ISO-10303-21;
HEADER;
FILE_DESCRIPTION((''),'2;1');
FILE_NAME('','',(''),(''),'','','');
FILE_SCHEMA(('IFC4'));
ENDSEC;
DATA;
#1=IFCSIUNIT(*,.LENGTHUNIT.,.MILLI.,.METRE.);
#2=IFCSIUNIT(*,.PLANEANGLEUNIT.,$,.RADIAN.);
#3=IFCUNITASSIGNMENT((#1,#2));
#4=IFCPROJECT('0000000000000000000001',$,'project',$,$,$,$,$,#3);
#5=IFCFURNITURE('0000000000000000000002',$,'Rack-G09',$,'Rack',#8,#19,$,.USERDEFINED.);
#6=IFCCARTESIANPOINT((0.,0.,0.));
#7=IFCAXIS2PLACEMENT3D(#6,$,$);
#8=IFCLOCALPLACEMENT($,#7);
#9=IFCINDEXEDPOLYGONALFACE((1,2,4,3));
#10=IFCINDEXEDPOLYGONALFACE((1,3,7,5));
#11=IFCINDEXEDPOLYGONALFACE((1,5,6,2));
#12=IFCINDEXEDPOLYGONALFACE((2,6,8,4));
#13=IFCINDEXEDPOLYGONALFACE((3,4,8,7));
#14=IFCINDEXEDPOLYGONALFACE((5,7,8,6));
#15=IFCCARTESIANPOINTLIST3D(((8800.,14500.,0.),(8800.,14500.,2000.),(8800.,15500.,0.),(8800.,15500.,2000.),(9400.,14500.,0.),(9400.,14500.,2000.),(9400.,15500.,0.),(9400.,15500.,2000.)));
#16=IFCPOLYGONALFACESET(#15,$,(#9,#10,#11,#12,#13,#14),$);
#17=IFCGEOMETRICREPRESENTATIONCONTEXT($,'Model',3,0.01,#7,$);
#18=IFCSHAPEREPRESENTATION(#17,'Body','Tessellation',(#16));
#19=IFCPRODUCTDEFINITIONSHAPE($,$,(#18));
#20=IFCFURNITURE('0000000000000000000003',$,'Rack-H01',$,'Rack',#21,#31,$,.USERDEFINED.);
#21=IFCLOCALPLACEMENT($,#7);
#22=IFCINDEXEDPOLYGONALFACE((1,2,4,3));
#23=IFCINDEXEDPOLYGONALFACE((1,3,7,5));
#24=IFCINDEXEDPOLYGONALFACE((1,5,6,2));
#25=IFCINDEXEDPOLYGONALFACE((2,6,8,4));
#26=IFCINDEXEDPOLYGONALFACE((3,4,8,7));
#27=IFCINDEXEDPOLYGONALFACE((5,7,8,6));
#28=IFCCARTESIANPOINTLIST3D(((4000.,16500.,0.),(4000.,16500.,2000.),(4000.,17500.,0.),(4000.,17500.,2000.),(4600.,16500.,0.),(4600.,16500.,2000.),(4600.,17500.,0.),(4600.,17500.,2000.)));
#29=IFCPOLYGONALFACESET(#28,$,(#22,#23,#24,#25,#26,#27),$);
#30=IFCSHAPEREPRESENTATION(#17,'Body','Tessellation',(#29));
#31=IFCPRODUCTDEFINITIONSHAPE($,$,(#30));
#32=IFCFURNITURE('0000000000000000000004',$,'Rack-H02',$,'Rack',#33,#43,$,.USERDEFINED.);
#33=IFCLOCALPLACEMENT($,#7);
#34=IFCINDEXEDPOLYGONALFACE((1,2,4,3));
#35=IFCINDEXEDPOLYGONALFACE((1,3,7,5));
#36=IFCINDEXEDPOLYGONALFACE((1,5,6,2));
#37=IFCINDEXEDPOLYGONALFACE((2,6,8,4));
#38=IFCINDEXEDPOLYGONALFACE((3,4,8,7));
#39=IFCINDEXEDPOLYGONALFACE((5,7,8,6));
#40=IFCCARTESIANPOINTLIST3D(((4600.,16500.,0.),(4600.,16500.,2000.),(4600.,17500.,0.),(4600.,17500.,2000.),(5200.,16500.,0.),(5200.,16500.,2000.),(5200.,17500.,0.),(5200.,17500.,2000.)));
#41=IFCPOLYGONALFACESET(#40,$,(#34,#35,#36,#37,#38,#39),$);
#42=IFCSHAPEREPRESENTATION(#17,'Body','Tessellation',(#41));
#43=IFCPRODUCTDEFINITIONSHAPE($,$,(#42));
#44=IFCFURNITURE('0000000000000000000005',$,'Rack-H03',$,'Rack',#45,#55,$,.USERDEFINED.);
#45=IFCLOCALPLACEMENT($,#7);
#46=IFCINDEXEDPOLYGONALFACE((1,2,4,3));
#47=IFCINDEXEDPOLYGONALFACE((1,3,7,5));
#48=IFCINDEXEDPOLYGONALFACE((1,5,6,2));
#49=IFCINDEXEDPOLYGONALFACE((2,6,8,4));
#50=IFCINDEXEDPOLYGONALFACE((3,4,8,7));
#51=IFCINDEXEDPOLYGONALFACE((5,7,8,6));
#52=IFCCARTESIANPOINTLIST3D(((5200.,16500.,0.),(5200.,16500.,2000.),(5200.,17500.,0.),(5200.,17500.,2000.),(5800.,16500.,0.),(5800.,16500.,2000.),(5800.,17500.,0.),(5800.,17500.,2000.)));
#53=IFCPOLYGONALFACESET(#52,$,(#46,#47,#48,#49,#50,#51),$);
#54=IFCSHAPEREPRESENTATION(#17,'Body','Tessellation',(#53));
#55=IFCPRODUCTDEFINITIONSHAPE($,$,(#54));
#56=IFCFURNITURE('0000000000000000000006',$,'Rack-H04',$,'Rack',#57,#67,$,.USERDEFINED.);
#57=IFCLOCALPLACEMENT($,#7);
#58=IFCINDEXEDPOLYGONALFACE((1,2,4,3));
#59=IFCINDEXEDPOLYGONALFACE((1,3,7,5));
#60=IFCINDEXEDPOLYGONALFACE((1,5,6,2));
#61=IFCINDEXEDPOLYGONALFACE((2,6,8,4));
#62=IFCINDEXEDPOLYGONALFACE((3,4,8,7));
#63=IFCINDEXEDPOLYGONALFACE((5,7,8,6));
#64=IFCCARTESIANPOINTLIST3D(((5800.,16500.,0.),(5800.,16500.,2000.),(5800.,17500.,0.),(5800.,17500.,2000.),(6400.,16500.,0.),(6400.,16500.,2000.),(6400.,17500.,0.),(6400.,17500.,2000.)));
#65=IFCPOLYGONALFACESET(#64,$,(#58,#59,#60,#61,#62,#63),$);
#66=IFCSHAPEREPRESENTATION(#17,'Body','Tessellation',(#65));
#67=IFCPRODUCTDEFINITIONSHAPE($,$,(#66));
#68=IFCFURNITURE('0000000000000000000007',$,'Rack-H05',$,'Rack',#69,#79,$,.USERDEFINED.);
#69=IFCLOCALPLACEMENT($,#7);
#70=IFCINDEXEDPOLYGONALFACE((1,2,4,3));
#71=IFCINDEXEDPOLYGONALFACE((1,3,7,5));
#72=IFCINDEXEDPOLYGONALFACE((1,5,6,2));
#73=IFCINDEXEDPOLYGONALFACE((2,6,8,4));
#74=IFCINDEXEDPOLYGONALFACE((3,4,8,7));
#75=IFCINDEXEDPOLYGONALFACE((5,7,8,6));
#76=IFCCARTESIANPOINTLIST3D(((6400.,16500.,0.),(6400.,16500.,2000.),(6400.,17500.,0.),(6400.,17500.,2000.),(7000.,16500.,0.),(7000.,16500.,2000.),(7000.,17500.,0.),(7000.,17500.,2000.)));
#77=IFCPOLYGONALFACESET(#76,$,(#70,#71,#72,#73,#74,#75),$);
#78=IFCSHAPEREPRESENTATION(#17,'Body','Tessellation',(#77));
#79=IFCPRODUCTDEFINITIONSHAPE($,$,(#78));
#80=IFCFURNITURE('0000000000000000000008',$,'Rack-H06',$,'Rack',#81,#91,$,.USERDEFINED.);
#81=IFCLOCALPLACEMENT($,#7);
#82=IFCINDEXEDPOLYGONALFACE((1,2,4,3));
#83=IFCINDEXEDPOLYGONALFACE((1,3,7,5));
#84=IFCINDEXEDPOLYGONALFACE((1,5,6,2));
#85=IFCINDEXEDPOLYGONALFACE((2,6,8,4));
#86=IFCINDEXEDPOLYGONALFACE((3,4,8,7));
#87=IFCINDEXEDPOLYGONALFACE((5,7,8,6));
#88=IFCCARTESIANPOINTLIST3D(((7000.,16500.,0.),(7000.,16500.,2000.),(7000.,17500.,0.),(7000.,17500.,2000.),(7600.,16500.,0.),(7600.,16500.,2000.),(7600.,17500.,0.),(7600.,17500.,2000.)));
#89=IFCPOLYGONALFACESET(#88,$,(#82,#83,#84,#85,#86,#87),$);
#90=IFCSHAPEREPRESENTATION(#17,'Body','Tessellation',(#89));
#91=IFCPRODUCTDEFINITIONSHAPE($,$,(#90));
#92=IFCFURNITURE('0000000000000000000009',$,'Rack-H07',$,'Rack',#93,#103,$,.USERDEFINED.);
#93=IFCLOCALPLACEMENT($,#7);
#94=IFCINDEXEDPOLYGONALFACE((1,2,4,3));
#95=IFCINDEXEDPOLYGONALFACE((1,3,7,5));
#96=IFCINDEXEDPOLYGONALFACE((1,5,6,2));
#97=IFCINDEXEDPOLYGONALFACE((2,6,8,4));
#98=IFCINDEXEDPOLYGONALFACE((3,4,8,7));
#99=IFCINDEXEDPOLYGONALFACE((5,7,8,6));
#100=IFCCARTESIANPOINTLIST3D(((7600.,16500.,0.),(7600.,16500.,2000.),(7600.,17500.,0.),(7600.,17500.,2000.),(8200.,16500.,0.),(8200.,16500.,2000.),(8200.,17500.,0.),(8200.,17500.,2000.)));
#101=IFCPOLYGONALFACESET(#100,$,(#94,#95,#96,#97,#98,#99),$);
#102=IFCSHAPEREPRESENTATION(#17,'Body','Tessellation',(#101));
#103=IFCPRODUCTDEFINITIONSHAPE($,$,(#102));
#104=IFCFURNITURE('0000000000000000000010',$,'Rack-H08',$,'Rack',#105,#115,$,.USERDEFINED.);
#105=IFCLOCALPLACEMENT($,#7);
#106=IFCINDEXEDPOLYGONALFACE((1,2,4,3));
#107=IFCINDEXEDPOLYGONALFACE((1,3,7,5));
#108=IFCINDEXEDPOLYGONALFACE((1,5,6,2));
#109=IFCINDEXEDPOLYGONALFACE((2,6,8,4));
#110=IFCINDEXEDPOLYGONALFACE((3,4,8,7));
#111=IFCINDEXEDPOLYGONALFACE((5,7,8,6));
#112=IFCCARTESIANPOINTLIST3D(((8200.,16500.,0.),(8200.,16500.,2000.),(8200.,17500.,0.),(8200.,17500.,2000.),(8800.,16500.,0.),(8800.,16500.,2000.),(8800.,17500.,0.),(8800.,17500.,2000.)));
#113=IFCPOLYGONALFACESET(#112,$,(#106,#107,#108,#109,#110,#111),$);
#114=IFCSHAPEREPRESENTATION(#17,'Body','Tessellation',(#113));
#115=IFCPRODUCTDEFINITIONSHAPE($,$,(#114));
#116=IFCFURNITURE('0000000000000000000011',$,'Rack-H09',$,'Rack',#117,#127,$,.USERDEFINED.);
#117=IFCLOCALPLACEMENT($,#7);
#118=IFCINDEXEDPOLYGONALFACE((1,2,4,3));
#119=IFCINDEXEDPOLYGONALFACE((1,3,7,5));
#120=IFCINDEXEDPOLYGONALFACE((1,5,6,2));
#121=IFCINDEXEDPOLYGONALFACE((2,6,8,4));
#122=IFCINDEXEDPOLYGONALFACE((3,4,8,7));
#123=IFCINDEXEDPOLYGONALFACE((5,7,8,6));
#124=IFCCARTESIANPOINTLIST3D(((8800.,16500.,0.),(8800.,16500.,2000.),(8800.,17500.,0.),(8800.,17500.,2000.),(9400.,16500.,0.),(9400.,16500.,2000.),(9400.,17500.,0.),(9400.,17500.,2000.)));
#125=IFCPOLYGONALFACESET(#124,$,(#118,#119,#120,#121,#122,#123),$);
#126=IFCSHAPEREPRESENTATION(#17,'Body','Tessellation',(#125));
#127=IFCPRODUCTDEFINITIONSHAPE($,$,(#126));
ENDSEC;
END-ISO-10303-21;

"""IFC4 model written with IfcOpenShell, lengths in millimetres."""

from ifc_helpers import new_model, si_unit, frame, origin, place, context, project, polyline, outline, extrude, element, save


model = new_model("IFC4")

# Units and contexts
model_context = context("Model", 3, precision=0.01, world=origin())
ifc_project = project(units=[si_unit("LENGTHUNIT", "METRE", prefix="MILLI"), si_unit("PLANEANGLEUNIT", "RADIAN")])

# Furniture
for number, where, name in (
    (1, (9100.0, 15000.0, 0.0), "Rack-G09"),
    (2, (4300.0, 17000.0, 0.0), "Rack-H01"),
    (3, (4900.0, 17000.0, 0.0), "Rack-H02"),
    (4, (5500.0, 17000.0, 0.0), "Rack-H03"),
    (5, (6100.0, 17000.0, 0.0), "Rack-H04"),
    (6, (6700.0, 17000.0, 0.0), "Rack-H05"),
    (7, (7300.0, 17000.0, 0.0), "Rack-H06"),
    (8, (7900.0, 17000.0, 0.0), "Rack-H07"),
    (9, (8500.0, 17000.0, 0.0), "Rack-H08"),
    (10, (9100.0, 17000.0, 0.0), "Rack-H09"),
):
    element("IfcFurniture", number, at=place(None, frame(where)), Name=name, ObjectType="Rack", PredefinedType="USERDEFINED", context=model_context, shape_type="SweptSolid", body=[
        extrude(outline(polyline([(-300.0, -500.0), (300.0, -500.0), (300.0, 500.0), (-300.0, 500.0), (-300.0, -500.0)])), origin(), (0.0, 0.0, 1.0), 2000.0),
    ])

save(model, "model.ifc")
